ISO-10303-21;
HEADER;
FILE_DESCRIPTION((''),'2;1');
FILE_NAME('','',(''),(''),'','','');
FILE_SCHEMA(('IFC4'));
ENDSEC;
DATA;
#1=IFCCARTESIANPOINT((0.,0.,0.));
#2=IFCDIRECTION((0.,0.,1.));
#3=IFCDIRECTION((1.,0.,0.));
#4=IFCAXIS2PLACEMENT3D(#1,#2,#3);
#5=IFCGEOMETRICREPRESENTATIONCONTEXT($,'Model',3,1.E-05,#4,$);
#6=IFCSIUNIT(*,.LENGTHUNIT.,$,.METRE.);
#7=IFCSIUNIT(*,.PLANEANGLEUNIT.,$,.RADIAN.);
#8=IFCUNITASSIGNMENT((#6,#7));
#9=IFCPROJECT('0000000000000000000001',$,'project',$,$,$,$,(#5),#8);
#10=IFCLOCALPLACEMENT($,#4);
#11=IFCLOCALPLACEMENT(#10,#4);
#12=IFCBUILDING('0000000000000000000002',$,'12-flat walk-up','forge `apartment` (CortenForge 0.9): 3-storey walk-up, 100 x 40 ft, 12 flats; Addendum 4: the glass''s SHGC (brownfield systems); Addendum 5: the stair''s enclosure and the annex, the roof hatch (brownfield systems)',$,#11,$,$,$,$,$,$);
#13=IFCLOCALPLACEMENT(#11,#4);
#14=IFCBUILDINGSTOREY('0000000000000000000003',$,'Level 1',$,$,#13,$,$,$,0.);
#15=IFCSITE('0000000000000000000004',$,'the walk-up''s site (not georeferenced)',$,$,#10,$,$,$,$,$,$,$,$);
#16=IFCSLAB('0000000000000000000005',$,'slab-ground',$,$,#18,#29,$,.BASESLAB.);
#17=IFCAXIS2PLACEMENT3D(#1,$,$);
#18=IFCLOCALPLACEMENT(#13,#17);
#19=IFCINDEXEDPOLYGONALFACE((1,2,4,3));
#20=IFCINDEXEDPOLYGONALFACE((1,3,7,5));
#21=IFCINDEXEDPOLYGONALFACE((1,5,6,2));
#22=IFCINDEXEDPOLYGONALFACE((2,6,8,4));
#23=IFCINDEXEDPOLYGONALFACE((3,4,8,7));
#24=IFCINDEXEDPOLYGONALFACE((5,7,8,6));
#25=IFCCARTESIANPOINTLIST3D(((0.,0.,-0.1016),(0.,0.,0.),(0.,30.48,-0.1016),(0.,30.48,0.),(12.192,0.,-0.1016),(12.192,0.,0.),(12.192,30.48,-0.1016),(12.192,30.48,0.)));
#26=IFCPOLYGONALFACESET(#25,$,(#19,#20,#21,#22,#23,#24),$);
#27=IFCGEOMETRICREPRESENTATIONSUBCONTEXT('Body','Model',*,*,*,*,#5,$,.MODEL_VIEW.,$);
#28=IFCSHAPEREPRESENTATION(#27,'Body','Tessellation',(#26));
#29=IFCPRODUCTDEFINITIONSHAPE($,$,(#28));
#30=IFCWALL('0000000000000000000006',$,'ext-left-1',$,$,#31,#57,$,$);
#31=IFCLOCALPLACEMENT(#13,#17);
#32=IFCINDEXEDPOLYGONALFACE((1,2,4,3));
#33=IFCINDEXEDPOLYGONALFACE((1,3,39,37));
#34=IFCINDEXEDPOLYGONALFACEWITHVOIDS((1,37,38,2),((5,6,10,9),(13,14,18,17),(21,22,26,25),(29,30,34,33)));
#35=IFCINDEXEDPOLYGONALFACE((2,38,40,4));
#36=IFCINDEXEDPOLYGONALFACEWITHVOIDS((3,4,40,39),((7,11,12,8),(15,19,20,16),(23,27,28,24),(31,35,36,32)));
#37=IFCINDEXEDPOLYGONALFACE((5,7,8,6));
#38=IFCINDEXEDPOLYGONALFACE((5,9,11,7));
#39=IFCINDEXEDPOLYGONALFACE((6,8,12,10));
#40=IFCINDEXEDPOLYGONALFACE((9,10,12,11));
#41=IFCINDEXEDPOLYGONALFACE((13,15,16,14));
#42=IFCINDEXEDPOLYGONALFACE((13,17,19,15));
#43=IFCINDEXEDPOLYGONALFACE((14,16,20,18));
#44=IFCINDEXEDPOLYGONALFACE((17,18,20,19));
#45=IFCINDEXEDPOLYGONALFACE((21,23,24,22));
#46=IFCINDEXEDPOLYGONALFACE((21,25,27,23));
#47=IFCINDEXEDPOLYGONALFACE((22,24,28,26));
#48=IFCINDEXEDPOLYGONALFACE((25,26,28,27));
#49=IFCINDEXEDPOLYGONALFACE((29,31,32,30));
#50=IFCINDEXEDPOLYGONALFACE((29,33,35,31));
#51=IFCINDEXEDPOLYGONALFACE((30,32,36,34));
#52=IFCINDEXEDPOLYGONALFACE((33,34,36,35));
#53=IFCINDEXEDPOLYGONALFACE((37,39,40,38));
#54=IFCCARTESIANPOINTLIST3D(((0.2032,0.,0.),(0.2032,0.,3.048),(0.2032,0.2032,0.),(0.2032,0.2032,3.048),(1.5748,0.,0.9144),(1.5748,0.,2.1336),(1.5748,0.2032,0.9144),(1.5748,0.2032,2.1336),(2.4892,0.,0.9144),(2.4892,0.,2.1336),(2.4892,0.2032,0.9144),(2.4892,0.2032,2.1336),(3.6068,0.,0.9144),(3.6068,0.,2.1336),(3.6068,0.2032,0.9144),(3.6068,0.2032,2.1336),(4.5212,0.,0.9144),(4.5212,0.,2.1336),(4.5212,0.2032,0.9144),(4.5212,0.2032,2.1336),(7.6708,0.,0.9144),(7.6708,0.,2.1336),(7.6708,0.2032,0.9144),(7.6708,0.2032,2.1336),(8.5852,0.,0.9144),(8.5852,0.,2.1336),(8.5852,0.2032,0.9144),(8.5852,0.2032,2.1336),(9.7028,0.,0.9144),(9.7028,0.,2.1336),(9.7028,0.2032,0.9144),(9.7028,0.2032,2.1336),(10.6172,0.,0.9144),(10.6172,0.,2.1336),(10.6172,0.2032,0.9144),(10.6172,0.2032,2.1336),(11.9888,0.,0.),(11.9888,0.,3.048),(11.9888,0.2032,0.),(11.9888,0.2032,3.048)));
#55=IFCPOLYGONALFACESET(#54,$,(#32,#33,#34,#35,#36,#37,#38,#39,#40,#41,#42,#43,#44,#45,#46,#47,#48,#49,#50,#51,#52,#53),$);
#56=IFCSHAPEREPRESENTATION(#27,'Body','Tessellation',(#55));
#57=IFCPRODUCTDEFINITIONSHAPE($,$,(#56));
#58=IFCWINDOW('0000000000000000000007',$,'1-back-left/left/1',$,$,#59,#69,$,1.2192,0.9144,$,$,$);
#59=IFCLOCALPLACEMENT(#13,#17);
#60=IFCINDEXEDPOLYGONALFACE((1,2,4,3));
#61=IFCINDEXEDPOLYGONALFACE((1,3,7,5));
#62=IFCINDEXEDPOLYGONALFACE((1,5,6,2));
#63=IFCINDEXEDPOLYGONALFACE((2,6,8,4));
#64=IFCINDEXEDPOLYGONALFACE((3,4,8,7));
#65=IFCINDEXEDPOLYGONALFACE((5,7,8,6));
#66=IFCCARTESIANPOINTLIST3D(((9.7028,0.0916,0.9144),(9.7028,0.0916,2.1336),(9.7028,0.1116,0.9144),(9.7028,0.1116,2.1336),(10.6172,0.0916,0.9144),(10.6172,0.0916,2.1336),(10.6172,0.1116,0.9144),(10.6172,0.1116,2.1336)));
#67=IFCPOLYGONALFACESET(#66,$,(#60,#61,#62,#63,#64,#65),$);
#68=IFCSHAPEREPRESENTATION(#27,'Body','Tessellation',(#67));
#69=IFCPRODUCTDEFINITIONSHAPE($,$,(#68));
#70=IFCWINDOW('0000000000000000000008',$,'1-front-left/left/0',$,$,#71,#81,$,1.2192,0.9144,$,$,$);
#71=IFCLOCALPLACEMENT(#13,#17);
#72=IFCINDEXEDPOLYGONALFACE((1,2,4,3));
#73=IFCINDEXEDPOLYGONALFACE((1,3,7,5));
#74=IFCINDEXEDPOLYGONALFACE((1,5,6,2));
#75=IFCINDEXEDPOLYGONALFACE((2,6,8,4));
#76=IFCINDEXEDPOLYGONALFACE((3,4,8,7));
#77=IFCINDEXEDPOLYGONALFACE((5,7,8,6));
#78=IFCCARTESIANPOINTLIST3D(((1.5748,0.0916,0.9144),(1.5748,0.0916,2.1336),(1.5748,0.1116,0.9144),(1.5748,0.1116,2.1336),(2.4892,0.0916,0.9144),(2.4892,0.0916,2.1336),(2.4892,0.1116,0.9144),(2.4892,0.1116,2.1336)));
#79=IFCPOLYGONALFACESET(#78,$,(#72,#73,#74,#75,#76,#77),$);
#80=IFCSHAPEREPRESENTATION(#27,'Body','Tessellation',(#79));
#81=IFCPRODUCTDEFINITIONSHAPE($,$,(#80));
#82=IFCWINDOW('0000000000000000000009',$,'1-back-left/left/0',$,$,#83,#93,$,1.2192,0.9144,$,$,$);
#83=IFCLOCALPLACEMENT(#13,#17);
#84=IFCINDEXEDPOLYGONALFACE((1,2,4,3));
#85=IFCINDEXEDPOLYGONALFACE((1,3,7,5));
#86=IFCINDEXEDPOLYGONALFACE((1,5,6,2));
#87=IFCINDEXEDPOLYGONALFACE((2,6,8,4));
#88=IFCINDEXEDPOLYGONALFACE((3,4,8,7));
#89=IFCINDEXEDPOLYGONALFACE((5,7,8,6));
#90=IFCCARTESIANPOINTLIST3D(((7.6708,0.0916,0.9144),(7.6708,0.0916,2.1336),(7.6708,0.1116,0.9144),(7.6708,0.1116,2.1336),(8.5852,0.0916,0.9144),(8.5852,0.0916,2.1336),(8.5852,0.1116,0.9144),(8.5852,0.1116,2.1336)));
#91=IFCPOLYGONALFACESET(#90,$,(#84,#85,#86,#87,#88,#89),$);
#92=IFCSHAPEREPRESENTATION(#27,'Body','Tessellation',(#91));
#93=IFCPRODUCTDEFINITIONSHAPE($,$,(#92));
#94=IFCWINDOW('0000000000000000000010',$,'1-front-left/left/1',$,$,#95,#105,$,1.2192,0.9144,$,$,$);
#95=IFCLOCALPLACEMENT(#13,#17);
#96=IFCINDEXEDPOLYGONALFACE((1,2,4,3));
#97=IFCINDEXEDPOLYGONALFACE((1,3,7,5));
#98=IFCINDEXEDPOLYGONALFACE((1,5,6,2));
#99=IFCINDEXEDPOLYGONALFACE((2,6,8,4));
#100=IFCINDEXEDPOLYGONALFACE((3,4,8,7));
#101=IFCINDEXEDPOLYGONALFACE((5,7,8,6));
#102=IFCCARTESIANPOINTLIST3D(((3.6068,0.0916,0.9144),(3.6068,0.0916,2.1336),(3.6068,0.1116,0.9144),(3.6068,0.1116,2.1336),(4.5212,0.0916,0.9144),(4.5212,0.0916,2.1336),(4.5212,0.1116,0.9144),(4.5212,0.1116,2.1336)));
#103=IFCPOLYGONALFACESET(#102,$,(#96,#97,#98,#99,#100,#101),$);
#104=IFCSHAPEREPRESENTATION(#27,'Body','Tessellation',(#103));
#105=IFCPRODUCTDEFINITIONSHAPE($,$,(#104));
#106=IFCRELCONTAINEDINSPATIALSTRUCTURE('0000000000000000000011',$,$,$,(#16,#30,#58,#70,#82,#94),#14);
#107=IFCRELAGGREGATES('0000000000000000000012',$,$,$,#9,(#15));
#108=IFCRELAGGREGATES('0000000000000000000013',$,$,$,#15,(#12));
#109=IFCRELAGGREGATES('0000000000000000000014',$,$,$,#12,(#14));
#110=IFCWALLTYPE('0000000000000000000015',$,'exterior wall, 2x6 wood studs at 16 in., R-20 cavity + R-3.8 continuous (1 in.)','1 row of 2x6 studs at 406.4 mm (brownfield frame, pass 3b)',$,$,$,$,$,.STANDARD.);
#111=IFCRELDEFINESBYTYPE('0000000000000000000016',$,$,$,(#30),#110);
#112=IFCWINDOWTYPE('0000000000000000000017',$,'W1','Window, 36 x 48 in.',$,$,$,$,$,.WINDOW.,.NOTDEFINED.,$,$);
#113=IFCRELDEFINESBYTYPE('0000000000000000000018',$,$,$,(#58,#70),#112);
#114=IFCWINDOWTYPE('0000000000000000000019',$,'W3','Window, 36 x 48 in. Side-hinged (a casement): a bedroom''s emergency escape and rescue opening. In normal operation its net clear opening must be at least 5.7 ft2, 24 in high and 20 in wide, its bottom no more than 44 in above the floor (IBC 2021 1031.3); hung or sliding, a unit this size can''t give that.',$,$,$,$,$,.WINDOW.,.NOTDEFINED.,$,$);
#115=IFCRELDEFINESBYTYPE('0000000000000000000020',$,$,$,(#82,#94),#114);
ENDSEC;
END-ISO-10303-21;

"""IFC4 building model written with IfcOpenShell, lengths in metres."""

from ifc_helpers import new_model, si_unit, frame, frame_2d, origin, origin_with_axes, place, context, subcontext, project, spatial, rectangle, extrude, type_object, element, fill, save


model = new_model("IFC4")

# Units and contexts
model_context = context("Model", 3, precision=1e-05, world=origin_with_axes())
body_context = subcontext(model_context, "Body", "Model", "MODEL_VIEW")
ifc_project = project(units=[si_unit("LENGTHUNIT", "METRE"), si_unit("PLANEANGLEUNIT", "RADIAN")], contexts=[model_context])

# Site, building, storey
site_placement = place(None, origin_with_axes())
site = spatial("IfcSite", under=ifc_project, at=site_placement, Name="the walk-up's site (not georeferenced)")
building_placement = place(site_placement, origin_with_axes())
building = spatial("IfcBuilding", under=site, at=building_placement, Name="12-flat walk-up", Description="forge `apartment` (CortenForge 0.9): 3-storey walk-up, 100 x 40 ft, 12 flats; Addendum 4: the glass's SHGC (brownfield systems); Addendum 5: the stair's enclosure and the annex, the roof hatch (brownfield systems)")
storey_placement = place(building_placement, origin_with_axes())
storey = spatial("IfcBuildingStorey", under=building, at=storey_placement, Name="Level 1", Elevation=0.0)

# Slab
slab_placement = place(storey_placement, frame((0.0, 0.0, -0.1016), z_axis=(0.0, 0.0, 1.0), x_axis=(1.0, 0.0, 0.0)))
element("IfcSlab", 1, at=slab_placement, inside=storey, Name="slab-ground", PredefinedType="BASESLAB", context=body_context, shape_type="SweptSolid", body=[
    extrude(rectangle(XDim=12.192, YDim=30.48, at=frame_2d((6.096, 15.24))), origin(), (0.0, 0.0, 1.0), 0.1016),
])

# Wall, openings, windows
wall_type = type_object("IfcWallType", Name="exterior wall, 2x6 wood studs at 16 in., R-20 cavity + R-3.8 continuous (1 in.)", Description="1 row of 2x6 studs at 406.4 mm (brownfield frame, pass 3b)", PredefinedType="STANDARD")
wall_placement = place(storey_placement, frame((0.2032, 0.0, 0.0), z_axis=(0.0, 0.0, 1.0), x_axis=(1.0, 0.0, 0.0)))
wall = element("IfcWall", 2, at=wall_placement, inside=storey, type_object=wall_type, Name="ext-left-1", context=body_context, shape_type="SweptSolid", body=[
    extrude(rectangle(XDim=11.7856, YDim=0.2032, at=frame_2d((5.8928, 0.1016))), origin(), (0.0, 0.0, 1.0), 3.048),
])
opening_1_placement = place(wall_placement, frame((7.4676, 0.0, 0.9144), z_axis=(0.0, 0.0, 1.0), x_axis=(1.0, 0.0, 0.0)))
opening_1 = element("IfcOpeningElement", 3, at=opening_1_placement, cuts=wall, PredefinedType="OPENING", context=body_context, shape_type="SweptSolid", body=[
    extrude(rectangle(XDim=0.9144, YDim=0.2032, at=frame_2d((0.4572, 0.1016))), origin(), (0.0, 0.0, 1.0), 1.2192),
])
opening_2_placement = place(wall_placement, frame((9.4996, 0.0, 0.9144), z_axis=(0.0, 0.0, 1.0), x_axis=(1.0, 0.0, 0.0)))
opening_2 = element("IfcOpeningElement", 4, at=opening_2_placement, cuts=wall, PredefinedType="OPENING", context=body_context, shape_type="SweptSolid", body=[
    extrude(rectangle(XDim=0.9144, YDim=0.2032, at=frame_2d((0.4572, 0.1016))), origin(), (0.0, 0.0, 1.0), 1.2192),
])
opening_3_placement = place(wall_placement, frame((1.3716, 0.0, 0.9144), z_axis=(0.0, 0.0, 1.0), x_axis=(1.0, 0.0, 0.0)))
opening_3 = element("IfcOpeningElement", 5, at=opening_3_placement, cuts=wall, PredefinedType="OPENING", context=body_context, shape_type="SweptSolid", body=[
    extrude(rectangle(XDim=0.9144, YDim=0.2032, at=frame_2d((0.4572, 0.1016))), origin(), (0.0, 0.0, 1.0), 1.2192),
])
opening_4_placement = place(wall_placement, frame((3.4036, 0.0, 0.9144), z_axis=(0.0, 0.0, 1.0), x_axis=(1.0, 0.0, 0.0)))
opening_4 = element("IfcOpeningElement", 6, at=opening_4_placement, cuts=wall, PredefinedType="OPENING", context=body_context, shape_type="SweptSolid", body=[
    extrude(rectangle(XDim=0.9144, YDim=0.2032, at=frame_2d((0.4572, 0.1016))), origin(), (0.0, 0.0, 1.0), 1.2192),
])
window_type_1 = type_object("IfcWindowType", Name="W1", Description="Window, 36 x 48 in.", PartitioningType="NOTDEFINED", PredefinedType="WINDOW")
window_1_placement = place(opening_2_placement, frame((0.0, 0.0916, 0.0), z_axis=(0.0, 0.0, 1.0), x_axis=(1.0, 0.0, 0.0)))
window_1 = element("IfcWindow", 7, at=window_1_placement, inside=storey, type_object=window_type_1, Name="1-back-left/left/1", OverallHeight=1.2192, OverallWidth=0.9144, context=body_context, shape_type="SweptSolid", body=[
    extrude(rectangle(XDim=0.9144, YDim=0.02, at=frame_2d((0.4572, 0.01))), origin(), (0.0, 0.0, 1.0), 1.2192),
])
fill(opening_2, window_1)
window_2_placement = place(opening_3_placement, frame((0.0, 0.0916, 0.0), z_axis=(0.0, 0.0, 1.0), x_axis=(1.0, 0.0, 0.0)))
window_2 = element("IfcWindow", 8, at=window_2_placement, inside=storey, type_object=window_type_1, Name="1-front-left/left/0", OverallHeight=1.2192, OverallWidth=0.9144, context=body_context, shape_type="SweptSolid", body=[
    extrude(rectangle(XDim=0.9144, YDim=0.02, at=frame_2d((0.4572, 0.01))), origin(), (0.0, 0.0, 1.0), 1.2192),
])
fill(opening_3, window_2)
window_type_2 = type_object("IfcWindowType", Name="W3", Description="Window, 36 x 48 in. Side-hinged (a casement): a bedroom's emergency escape and rescue opening. In normal operation its net clear opening must be at least 5.7 ft2, 24 in high and 20 in wide, its bottom no more than 44 in above the floor (IBC 2021 1031.3); hung or sliding, a unit this size can't give that.", PartitioningType="NOTDEFINED", PredefinedType="WINDOW")
window_3_placement = place(opening_1_placement, frame((0.0, 0.0916, 0.0), z_axis=(0.0, 0.0, 1.0), x_axis=(1.0, 0.0, 0.0)))
window_3 = element("IfcWindow", 9, at=window_3_placement, inside=storey, type_object=window_type_2, Name="1-back-left/left/0", OverallHeight=1.2192, OverallWidth=0.9144, context=body_context, shape_type="SweptSolid", body=[
    extrude(rectangle(XDim=0.9144, YDim=0.02, at=frame_2d((0.4572, 0.01))), origin(), (0.0, 0.0, 1.0), 1.2192),
])
fill(opening_1, window_3)
window_4_placement = place(opening_4_placement, frame((0.0, 0.0916, 0.0), z_axis=(0.0, 0.0, 1.0), x_axis=(1.0, 0.0, 0.0)))
window_4 = element("IfcWindow", 10, at=window_4_placement, inside=storey, type_object=window_type_2, Name="1-front-left/left/1", OverallHeight=1.2192, OverallWidth=0.9144, context=body_context, shape_type="SweptSolid", body=[
    extrude(rectangle(XDim=0.9144, YDim=0.02, at=frame_2d((0.4572, 0.01))), origin(), (0.0, 0.0, 1.0), 1.2192),
])
fill(opening_4, window_4)

save(model, "model.ifc")
